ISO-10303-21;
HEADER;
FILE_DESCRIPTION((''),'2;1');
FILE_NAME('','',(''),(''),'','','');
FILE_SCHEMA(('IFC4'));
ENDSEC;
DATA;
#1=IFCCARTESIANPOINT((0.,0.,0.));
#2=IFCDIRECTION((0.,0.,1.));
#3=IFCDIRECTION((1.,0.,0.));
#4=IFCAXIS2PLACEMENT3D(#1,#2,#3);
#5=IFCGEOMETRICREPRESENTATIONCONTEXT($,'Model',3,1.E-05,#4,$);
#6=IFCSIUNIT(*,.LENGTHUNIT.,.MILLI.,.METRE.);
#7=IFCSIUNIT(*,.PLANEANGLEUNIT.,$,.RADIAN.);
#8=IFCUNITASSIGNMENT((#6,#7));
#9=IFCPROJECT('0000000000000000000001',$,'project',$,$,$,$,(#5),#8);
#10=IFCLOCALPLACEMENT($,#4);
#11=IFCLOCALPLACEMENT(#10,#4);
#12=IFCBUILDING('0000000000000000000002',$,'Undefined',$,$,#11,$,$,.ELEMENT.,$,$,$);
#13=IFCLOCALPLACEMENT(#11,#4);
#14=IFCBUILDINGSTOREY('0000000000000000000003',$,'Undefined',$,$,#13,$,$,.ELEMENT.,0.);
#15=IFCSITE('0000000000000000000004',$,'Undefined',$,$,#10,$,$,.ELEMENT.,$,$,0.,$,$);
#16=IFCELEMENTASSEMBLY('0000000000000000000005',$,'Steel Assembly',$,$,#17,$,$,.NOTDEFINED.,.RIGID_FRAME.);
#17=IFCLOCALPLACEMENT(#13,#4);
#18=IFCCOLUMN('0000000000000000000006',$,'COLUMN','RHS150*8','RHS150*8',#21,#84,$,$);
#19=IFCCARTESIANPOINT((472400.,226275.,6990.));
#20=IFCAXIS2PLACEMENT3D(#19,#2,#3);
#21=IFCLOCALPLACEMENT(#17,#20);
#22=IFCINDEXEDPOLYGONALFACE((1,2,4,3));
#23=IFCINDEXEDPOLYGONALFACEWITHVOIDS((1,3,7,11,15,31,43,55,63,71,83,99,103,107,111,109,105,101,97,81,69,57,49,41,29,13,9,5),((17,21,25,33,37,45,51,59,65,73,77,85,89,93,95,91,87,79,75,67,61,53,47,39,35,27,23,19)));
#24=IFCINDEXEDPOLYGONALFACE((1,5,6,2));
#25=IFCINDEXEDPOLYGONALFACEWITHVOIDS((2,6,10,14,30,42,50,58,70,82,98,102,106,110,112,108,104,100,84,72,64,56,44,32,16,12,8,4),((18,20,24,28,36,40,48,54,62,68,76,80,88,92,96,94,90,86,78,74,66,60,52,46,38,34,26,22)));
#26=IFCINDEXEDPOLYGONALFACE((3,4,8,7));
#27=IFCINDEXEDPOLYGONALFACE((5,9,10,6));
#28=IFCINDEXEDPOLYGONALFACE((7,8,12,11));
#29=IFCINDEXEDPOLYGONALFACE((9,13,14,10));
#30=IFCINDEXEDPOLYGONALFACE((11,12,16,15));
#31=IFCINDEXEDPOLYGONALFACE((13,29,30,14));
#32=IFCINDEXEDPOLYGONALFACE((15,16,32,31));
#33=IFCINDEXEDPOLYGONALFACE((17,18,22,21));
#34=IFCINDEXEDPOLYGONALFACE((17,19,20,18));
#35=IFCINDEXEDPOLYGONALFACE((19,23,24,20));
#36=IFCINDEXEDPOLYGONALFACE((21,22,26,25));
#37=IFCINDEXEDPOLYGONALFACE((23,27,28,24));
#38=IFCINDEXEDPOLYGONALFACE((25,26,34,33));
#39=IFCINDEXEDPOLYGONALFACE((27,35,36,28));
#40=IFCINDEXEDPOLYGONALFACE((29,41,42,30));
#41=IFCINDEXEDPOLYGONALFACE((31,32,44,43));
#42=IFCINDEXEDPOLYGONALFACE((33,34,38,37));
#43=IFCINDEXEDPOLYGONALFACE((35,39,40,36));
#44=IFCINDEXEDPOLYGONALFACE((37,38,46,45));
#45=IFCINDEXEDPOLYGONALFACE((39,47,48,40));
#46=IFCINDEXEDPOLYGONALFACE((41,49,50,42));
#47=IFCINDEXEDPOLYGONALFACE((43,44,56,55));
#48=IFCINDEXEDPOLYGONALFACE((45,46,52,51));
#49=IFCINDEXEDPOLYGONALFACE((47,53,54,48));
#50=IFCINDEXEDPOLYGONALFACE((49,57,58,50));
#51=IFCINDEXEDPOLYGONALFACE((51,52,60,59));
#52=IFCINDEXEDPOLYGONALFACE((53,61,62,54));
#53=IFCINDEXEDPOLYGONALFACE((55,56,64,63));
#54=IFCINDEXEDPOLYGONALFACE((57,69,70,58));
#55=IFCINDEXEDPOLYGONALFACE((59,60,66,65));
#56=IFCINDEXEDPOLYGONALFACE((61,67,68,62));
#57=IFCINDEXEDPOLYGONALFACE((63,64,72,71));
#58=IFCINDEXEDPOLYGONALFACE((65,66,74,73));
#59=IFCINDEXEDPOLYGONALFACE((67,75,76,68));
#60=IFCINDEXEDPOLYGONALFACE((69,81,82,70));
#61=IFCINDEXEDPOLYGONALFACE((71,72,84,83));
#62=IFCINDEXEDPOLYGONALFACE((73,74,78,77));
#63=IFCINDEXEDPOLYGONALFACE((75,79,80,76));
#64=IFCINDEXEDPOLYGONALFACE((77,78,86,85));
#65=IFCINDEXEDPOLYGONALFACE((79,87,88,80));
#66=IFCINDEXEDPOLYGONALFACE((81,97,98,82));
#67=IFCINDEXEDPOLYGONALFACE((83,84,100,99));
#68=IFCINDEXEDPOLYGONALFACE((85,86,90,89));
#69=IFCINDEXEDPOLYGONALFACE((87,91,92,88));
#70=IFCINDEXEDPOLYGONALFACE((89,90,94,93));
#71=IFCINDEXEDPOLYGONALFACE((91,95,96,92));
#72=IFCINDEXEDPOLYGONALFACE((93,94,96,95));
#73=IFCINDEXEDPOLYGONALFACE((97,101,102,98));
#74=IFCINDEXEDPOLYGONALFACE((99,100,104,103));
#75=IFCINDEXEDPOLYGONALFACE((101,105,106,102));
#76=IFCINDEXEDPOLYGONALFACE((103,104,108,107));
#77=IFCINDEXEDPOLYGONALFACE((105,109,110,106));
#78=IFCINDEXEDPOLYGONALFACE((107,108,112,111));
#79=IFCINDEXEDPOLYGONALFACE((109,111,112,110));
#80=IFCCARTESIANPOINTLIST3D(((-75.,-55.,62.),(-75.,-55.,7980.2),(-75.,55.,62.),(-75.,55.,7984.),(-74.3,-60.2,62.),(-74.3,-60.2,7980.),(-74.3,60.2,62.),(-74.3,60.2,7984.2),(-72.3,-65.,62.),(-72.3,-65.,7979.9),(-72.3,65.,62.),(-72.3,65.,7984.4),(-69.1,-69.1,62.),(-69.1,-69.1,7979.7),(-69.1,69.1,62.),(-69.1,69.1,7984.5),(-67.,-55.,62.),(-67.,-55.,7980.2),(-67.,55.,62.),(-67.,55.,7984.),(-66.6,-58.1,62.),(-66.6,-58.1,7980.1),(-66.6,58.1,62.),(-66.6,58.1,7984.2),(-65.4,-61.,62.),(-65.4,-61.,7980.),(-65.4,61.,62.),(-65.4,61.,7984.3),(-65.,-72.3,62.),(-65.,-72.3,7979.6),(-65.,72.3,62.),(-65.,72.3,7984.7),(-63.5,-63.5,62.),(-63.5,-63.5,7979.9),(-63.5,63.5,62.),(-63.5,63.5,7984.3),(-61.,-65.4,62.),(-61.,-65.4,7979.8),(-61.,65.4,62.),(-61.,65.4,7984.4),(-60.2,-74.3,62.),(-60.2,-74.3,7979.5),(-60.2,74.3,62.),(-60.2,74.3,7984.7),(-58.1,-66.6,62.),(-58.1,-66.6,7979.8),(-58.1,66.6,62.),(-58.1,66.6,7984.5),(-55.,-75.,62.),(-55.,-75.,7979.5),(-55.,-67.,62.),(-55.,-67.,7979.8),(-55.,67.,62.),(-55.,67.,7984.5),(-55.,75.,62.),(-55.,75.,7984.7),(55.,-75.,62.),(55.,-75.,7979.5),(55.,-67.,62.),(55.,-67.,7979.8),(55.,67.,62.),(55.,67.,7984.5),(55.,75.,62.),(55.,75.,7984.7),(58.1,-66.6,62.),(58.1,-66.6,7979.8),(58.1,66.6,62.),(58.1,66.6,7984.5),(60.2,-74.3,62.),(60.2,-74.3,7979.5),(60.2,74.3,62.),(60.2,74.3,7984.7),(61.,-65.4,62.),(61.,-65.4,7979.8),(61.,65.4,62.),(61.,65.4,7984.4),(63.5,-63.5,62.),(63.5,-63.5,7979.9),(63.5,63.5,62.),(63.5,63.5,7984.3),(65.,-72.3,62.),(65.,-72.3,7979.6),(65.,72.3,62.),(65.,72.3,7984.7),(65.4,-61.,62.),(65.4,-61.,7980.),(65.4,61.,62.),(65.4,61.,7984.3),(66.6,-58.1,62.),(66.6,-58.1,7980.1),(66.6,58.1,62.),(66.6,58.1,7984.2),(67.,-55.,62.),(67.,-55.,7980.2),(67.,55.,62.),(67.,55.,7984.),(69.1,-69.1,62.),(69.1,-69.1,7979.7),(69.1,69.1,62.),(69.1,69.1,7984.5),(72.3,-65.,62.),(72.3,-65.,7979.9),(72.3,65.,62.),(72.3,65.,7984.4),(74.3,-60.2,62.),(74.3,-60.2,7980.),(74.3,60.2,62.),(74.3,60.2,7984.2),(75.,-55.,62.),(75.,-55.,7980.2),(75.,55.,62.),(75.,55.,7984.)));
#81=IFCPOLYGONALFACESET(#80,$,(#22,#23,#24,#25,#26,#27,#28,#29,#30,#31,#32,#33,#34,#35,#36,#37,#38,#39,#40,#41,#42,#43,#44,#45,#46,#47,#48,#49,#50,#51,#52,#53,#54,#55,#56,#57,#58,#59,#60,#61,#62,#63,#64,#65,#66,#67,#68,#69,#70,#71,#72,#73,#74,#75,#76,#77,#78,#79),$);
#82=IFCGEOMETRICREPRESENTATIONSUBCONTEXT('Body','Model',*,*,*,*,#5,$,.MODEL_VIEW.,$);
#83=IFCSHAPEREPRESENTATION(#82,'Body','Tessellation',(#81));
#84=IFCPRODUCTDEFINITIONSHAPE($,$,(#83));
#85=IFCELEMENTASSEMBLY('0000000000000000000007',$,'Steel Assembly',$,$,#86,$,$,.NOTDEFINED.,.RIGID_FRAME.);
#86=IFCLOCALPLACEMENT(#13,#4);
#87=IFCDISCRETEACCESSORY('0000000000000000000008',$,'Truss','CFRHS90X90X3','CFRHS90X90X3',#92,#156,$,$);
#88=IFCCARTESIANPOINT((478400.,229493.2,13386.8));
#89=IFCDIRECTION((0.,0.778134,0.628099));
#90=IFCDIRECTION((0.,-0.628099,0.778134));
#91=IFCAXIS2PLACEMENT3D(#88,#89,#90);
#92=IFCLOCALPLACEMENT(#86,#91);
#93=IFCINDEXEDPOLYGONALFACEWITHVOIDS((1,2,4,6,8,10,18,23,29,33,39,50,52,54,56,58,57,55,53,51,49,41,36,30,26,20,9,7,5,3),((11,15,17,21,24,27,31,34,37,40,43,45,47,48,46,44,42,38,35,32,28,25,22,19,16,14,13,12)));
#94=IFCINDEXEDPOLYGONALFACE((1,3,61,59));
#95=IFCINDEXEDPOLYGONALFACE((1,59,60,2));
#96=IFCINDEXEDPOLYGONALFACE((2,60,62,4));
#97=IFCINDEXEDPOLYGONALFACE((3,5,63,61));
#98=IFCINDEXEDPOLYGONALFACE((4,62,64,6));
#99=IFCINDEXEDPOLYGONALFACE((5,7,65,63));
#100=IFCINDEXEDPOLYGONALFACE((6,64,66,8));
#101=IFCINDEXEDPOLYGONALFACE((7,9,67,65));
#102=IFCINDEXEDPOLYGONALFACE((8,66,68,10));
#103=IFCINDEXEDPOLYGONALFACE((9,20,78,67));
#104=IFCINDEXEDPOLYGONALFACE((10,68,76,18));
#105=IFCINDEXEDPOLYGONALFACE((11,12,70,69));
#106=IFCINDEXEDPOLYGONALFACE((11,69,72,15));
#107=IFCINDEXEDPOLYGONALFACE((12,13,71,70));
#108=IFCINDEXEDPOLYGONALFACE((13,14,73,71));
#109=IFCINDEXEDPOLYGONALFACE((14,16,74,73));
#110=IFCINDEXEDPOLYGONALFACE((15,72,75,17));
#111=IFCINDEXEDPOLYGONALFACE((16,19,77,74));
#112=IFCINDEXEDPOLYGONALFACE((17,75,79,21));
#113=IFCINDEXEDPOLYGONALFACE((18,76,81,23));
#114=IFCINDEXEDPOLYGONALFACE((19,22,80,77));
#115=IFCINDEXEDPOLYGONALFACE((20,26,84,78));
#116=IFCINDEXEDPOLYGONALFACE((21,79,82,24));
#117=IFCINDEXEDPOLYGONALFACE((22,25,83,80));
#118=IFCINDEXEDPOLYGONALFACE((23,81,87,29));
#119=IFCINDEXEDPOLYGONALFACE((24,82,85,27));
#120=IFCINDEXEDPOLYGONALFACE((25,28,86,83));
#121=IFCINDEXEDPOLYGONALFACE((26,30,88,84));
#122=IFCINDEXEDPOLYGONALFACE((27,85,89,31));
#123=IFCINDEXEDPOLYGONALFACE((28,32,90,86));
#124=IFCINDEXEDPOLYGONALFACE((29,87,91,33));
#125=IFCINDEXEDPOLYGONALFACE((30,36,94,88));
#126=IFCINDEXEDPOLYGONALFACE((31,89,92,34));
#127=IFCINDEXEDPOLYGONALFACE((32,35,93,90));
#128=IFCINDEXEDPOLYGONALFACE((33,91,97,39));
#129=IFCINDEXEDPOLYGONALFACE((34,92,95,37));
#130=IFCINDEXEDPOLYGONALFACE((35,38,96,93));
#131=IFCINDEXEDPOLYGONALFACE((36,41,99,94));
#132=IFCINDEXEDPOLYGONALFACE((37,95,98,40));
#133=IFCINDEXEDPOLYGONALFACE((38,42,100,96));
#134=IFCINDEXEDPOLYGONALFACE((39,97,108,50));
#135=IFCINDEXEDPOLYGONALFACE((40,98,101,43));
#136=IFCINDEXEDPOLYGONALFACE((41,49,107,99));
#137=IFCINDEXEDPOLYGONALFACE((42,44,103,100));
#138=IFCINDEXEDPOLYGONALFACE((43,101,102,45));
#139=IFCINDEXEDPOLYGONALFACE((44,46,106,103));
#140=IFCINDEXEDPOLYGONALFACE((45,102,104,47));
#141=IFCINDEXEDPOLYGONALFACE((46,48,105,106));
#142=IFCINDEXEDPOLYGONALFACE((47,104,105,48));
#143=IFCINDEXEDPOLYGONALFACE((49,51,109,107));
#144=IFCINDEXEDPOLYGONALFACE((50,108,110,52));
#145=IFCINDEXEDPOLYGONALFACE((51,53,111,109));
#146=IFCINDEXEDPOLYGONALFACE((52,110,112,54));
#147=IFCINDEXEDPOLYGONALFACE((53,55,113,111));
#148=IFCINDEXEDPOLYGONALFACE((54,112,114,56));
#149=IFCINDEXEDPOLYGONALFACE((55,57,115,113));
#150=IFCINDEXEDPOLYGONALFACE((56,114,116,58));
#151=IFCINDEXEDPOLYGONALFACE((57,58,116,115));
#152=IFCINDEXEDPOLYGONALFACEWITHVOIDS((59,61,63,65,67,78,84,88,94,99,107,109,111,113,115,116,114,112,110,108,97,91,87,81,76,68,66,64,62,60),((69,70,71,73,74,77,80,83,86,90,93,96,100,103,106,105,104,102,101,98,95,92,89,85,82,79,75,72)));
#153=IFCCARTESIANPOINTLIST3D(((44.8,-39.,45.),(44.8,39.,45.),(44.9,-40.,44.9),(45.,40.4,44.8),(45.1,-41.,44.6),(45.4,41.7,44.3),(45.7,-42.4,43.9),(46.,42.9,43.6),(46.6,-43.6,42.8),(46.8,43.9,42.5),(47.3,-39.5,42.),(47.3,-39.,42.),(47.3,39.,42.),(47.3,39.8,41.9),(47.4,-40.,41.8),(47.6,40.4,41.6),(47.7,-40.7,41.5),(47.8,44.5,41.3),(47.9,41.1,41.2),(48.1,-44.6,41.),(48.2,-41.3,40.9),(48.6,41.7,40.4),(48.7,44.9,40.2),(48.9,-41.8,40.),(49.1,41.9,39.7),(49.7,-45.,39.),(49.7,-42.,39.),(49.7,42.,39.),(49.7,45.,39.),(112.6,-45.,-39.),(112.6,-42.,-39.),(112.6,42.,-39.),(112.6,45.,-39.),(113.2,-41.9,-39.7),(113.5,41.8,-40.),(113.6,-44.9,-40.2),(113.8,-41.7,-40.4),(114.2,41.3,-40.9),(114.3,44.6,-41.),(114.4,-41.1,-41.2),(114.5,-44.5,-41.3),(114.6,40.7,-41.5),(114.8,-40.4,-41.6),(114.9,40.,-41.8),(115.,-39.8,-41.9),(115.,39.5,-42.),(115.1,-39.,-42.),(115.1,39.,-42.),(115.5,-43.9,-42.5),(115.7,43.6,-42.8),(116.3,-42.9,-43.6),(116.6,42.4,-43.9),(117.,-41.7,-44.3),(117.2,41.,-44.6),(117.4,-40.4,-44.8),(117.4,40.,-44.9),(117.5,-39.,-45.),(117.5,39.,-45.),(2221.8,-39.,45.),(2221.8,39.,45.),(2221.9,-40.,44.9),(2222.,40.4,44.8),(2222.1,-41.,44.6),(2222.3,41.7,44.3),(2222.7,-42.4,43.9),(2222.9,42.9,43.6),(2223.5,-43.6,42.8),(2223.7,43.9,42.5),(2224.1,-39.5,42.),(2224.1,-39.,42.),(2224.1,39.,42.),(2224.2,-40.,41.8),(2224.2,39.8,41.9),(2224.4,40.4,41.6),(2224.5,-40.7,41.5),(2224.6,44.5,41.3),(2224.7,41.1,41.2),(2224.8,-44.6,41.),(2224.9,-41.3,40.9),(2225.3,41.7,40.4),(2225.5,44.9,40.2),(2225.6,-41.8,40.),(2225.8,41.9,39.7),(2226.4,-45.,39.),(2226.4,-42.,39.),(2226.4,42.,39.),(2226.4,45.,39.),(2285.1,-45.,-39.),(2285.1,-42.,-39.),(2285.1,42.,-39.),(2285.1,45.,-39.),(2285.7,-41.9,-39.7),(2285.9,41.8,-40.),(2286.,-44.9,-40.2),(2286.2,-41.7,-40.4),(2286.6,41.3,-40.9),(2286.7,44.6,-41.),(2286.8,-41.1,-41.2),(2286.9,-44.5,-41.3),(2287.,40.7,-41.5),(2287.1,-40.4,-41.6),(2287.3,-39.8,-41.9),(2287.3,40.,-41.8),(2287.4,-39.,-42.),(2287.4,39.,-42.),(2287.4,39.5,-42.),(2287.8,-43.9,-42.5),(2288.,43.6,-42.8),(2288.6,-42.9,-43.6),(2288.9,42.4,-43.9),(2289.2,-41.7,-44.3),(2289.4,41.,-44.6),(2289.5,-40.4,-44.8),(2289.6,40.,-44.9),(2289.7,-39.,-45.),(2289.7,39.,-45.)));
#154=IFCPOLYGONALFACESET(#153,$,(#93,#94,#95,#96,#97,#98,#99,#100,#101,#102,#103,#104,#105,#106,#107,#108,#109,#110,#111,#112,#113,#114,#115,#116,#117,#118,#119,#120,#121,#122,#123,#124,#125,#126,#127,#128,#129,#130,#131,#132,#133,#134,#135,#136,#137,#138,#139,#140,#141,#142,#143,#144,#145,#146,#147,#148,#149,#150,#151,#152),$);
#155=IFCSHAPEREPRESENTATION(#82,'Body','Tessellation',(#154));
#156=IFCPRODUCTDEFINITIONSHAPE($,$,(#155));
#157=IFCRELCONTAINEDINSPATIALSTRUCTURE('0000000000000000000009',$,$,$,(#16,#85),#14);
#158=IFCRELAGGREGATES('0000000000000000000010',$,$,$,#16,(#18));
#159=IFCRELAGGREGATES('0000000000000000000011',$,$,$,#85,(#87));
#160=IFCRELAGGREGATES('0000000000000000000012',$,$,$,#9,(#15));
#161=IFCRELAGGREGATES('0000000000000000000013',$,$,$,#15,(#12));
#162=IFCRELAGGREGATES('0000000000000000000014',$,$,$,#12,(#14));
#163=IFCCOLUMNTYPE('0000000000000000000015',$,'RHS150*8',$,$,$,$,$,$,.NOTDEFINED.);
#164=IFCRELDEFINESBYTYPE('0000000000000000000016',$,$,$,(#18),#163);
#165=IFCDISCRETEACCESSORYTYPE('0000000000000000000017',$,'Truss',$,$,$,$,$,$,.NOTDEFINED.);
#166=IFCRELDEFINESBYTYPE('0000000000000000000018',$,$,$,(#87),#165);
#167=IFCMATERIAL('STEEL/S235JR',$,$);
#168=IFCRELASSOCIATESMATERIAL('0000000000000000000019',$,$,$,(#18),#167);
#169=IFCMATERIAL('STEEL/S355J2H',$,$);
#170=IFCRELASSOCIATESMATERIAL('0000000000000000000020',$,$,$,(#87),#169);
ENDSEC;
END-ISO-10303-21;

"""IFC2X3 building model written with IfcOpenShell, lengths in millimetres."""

from ifc_helpers import new_model, si_unit, frame, origin_with_axes, origin_2d_with_axis, place, context, subcontext, project, spatial, hollow_rectangle, extrude, clip, halfspace, material, type_object, element, aggregate, save


model = new_model("IFC2X3")

# Units and contexts
model_context = context("Model", 3, precision=1e-05, world=origin_with_axes())
body_context = subcontext(model_context, "Body", "Model", "MODEL_VIEW")
ifc_project = project(units=[si_unit("LENGTHUNIT", "METRE", prefix="MILLI"), si_unit("PLANEANGLEUNIT", "RADIAN")], contexts=[model_context])

# Site, building, storey
site_placement = place(None, origin_with_axes())
site = spatial("IfcSite", under=ifc_project, at=site_placement, Name="Undefined", CompositionType="ELEMENT", RefElevation=0.0)
building_placement = place(site_placement, origin_with_axes())
building = spatial("IfcBuilding", under=site, at=building_placement, Name="Undefined", CompositionType="ELEMENT")
storey_placement = place(building_placement, origin_with_axes())
storey = spatial("IfcBuildingStorey", under=building, at=storey_placement, Name="Undefined", CompositionType="ELEMENT", Elevation=0.0)

# Element assembly, column
assembly_1_placement = place(storey_placement, origin_with_axes())
assembly_1 = element("IfcElementAssembly", 1, at=assembly_1_placement, inside=storey, Name="Steel Assembly", AssemblyPlace="NOTDEFINED", PredefinedType="RIGID_FRAME")
ifc_material_1 = material(Name="STEEL/S235JR")
column_type = type_object("IfcColumnType", Name="RHS150*8", PredefinedType="NOTDEFINED")
column_placement = place(assembly_1_placement, frame((472400.0, 226275.0, 6990.0), z_axis=(0.0, 0.0, 1.0), x_axis=(1.0, 0.0, 0.0)))
column = element("IfcColumn", 2, at=column_placement, type_object=column_type, material=ifc_material_1, Name="COLUMN", Description="RHS150*8", ObjectType="RHS150*8", context=body_context, shape_type="Clipping", body=[
    clip(extrude(hollow_rectangle(XDim=150.0, YDim=150.0, WallThickness=8.0, InnerFilletRadius=12.0, OuterFilletRadius=20.0, at=origin_2d_with_axis()), frame((0.0, 0.0, 7984.8), z_axis=(0.0, 0.0, -1.0), x_axis=(-1.0, 0.0, 0.0)), (0.0, 0.0, 1.0), 7922.8), halfspace(frame((0.0, -89.2, 7979.0), z_axis=(0.0, 0.034899, -0.999391), x_axis=(1.0, 0.0, 0.0)), True)),
])
aggregate(assembly_1, [column])

# Element assembly, discrete accessory
assembly_2_placement = place(storey_placement, origin_with_axes())
assembly_2 = element("IfcElementAssembly", 3, at=assembly_2_placement, inside=storey, Name="Steel Assembly", AssemblyPlace="NOTDEFINED", PredefinedType="RIGID_FRAME")
ifc_material_2 = material(Name="STEEL/S355J2H")
discrete_accessory_type_1 = type_object("IfcDiscreteAccessoryType", Name="Truss")
discrete_accessory_1_placement = place(assembly_2_placement, frame((478400.0, 229493.2, 13386.8), z_axis=(0.0, 0.778134, 0.628099), x_axis=(0.0, -0.628099, 0.778134)))
discrete_accessory_1 = element("IfcDiscreteAccessory", 4, at=discrete_accessory_1_placement, type_object=discrete_accessory_type_1, material=ifc_material_2, Name="Truss", Description="CFRHS90X90X3", ObjectType="CFRHS90X90X3", context=body_context, shape_type="Clipping", body=[
    clip(clip(extrude(hollow_rectangle(XDim=90.0, YDim=90.0, WallThickness=3.0, InnerFilletRadius=3.0, OuterFilletRadius=6.0, at=origin_2d_with_axis()), frame((2329.6, 0.0, 0.0), z_axis=(-1.0, 0.0, 0.0), x_axis=(0.0, -1.0, 0.0)), (0.0, 0.0, 1.0), 2322.4), halfspace(frame((2221.8, 0.0, 45.0), z_axis=(-0.798627, 0.0, -0.601827), x_axis=(0.601827, 0.0, -0.798627)), True)), halfspace(frame((44.8, 0.0, 45.0), z_axis=(-0.778134, 0.0, -0.628099), x_axis=(0.628099, 0.0, -0.778134)), False)),
])

aggregate(assembly_2, [discrete_accessory_1])

save(model, "model.ifc")
